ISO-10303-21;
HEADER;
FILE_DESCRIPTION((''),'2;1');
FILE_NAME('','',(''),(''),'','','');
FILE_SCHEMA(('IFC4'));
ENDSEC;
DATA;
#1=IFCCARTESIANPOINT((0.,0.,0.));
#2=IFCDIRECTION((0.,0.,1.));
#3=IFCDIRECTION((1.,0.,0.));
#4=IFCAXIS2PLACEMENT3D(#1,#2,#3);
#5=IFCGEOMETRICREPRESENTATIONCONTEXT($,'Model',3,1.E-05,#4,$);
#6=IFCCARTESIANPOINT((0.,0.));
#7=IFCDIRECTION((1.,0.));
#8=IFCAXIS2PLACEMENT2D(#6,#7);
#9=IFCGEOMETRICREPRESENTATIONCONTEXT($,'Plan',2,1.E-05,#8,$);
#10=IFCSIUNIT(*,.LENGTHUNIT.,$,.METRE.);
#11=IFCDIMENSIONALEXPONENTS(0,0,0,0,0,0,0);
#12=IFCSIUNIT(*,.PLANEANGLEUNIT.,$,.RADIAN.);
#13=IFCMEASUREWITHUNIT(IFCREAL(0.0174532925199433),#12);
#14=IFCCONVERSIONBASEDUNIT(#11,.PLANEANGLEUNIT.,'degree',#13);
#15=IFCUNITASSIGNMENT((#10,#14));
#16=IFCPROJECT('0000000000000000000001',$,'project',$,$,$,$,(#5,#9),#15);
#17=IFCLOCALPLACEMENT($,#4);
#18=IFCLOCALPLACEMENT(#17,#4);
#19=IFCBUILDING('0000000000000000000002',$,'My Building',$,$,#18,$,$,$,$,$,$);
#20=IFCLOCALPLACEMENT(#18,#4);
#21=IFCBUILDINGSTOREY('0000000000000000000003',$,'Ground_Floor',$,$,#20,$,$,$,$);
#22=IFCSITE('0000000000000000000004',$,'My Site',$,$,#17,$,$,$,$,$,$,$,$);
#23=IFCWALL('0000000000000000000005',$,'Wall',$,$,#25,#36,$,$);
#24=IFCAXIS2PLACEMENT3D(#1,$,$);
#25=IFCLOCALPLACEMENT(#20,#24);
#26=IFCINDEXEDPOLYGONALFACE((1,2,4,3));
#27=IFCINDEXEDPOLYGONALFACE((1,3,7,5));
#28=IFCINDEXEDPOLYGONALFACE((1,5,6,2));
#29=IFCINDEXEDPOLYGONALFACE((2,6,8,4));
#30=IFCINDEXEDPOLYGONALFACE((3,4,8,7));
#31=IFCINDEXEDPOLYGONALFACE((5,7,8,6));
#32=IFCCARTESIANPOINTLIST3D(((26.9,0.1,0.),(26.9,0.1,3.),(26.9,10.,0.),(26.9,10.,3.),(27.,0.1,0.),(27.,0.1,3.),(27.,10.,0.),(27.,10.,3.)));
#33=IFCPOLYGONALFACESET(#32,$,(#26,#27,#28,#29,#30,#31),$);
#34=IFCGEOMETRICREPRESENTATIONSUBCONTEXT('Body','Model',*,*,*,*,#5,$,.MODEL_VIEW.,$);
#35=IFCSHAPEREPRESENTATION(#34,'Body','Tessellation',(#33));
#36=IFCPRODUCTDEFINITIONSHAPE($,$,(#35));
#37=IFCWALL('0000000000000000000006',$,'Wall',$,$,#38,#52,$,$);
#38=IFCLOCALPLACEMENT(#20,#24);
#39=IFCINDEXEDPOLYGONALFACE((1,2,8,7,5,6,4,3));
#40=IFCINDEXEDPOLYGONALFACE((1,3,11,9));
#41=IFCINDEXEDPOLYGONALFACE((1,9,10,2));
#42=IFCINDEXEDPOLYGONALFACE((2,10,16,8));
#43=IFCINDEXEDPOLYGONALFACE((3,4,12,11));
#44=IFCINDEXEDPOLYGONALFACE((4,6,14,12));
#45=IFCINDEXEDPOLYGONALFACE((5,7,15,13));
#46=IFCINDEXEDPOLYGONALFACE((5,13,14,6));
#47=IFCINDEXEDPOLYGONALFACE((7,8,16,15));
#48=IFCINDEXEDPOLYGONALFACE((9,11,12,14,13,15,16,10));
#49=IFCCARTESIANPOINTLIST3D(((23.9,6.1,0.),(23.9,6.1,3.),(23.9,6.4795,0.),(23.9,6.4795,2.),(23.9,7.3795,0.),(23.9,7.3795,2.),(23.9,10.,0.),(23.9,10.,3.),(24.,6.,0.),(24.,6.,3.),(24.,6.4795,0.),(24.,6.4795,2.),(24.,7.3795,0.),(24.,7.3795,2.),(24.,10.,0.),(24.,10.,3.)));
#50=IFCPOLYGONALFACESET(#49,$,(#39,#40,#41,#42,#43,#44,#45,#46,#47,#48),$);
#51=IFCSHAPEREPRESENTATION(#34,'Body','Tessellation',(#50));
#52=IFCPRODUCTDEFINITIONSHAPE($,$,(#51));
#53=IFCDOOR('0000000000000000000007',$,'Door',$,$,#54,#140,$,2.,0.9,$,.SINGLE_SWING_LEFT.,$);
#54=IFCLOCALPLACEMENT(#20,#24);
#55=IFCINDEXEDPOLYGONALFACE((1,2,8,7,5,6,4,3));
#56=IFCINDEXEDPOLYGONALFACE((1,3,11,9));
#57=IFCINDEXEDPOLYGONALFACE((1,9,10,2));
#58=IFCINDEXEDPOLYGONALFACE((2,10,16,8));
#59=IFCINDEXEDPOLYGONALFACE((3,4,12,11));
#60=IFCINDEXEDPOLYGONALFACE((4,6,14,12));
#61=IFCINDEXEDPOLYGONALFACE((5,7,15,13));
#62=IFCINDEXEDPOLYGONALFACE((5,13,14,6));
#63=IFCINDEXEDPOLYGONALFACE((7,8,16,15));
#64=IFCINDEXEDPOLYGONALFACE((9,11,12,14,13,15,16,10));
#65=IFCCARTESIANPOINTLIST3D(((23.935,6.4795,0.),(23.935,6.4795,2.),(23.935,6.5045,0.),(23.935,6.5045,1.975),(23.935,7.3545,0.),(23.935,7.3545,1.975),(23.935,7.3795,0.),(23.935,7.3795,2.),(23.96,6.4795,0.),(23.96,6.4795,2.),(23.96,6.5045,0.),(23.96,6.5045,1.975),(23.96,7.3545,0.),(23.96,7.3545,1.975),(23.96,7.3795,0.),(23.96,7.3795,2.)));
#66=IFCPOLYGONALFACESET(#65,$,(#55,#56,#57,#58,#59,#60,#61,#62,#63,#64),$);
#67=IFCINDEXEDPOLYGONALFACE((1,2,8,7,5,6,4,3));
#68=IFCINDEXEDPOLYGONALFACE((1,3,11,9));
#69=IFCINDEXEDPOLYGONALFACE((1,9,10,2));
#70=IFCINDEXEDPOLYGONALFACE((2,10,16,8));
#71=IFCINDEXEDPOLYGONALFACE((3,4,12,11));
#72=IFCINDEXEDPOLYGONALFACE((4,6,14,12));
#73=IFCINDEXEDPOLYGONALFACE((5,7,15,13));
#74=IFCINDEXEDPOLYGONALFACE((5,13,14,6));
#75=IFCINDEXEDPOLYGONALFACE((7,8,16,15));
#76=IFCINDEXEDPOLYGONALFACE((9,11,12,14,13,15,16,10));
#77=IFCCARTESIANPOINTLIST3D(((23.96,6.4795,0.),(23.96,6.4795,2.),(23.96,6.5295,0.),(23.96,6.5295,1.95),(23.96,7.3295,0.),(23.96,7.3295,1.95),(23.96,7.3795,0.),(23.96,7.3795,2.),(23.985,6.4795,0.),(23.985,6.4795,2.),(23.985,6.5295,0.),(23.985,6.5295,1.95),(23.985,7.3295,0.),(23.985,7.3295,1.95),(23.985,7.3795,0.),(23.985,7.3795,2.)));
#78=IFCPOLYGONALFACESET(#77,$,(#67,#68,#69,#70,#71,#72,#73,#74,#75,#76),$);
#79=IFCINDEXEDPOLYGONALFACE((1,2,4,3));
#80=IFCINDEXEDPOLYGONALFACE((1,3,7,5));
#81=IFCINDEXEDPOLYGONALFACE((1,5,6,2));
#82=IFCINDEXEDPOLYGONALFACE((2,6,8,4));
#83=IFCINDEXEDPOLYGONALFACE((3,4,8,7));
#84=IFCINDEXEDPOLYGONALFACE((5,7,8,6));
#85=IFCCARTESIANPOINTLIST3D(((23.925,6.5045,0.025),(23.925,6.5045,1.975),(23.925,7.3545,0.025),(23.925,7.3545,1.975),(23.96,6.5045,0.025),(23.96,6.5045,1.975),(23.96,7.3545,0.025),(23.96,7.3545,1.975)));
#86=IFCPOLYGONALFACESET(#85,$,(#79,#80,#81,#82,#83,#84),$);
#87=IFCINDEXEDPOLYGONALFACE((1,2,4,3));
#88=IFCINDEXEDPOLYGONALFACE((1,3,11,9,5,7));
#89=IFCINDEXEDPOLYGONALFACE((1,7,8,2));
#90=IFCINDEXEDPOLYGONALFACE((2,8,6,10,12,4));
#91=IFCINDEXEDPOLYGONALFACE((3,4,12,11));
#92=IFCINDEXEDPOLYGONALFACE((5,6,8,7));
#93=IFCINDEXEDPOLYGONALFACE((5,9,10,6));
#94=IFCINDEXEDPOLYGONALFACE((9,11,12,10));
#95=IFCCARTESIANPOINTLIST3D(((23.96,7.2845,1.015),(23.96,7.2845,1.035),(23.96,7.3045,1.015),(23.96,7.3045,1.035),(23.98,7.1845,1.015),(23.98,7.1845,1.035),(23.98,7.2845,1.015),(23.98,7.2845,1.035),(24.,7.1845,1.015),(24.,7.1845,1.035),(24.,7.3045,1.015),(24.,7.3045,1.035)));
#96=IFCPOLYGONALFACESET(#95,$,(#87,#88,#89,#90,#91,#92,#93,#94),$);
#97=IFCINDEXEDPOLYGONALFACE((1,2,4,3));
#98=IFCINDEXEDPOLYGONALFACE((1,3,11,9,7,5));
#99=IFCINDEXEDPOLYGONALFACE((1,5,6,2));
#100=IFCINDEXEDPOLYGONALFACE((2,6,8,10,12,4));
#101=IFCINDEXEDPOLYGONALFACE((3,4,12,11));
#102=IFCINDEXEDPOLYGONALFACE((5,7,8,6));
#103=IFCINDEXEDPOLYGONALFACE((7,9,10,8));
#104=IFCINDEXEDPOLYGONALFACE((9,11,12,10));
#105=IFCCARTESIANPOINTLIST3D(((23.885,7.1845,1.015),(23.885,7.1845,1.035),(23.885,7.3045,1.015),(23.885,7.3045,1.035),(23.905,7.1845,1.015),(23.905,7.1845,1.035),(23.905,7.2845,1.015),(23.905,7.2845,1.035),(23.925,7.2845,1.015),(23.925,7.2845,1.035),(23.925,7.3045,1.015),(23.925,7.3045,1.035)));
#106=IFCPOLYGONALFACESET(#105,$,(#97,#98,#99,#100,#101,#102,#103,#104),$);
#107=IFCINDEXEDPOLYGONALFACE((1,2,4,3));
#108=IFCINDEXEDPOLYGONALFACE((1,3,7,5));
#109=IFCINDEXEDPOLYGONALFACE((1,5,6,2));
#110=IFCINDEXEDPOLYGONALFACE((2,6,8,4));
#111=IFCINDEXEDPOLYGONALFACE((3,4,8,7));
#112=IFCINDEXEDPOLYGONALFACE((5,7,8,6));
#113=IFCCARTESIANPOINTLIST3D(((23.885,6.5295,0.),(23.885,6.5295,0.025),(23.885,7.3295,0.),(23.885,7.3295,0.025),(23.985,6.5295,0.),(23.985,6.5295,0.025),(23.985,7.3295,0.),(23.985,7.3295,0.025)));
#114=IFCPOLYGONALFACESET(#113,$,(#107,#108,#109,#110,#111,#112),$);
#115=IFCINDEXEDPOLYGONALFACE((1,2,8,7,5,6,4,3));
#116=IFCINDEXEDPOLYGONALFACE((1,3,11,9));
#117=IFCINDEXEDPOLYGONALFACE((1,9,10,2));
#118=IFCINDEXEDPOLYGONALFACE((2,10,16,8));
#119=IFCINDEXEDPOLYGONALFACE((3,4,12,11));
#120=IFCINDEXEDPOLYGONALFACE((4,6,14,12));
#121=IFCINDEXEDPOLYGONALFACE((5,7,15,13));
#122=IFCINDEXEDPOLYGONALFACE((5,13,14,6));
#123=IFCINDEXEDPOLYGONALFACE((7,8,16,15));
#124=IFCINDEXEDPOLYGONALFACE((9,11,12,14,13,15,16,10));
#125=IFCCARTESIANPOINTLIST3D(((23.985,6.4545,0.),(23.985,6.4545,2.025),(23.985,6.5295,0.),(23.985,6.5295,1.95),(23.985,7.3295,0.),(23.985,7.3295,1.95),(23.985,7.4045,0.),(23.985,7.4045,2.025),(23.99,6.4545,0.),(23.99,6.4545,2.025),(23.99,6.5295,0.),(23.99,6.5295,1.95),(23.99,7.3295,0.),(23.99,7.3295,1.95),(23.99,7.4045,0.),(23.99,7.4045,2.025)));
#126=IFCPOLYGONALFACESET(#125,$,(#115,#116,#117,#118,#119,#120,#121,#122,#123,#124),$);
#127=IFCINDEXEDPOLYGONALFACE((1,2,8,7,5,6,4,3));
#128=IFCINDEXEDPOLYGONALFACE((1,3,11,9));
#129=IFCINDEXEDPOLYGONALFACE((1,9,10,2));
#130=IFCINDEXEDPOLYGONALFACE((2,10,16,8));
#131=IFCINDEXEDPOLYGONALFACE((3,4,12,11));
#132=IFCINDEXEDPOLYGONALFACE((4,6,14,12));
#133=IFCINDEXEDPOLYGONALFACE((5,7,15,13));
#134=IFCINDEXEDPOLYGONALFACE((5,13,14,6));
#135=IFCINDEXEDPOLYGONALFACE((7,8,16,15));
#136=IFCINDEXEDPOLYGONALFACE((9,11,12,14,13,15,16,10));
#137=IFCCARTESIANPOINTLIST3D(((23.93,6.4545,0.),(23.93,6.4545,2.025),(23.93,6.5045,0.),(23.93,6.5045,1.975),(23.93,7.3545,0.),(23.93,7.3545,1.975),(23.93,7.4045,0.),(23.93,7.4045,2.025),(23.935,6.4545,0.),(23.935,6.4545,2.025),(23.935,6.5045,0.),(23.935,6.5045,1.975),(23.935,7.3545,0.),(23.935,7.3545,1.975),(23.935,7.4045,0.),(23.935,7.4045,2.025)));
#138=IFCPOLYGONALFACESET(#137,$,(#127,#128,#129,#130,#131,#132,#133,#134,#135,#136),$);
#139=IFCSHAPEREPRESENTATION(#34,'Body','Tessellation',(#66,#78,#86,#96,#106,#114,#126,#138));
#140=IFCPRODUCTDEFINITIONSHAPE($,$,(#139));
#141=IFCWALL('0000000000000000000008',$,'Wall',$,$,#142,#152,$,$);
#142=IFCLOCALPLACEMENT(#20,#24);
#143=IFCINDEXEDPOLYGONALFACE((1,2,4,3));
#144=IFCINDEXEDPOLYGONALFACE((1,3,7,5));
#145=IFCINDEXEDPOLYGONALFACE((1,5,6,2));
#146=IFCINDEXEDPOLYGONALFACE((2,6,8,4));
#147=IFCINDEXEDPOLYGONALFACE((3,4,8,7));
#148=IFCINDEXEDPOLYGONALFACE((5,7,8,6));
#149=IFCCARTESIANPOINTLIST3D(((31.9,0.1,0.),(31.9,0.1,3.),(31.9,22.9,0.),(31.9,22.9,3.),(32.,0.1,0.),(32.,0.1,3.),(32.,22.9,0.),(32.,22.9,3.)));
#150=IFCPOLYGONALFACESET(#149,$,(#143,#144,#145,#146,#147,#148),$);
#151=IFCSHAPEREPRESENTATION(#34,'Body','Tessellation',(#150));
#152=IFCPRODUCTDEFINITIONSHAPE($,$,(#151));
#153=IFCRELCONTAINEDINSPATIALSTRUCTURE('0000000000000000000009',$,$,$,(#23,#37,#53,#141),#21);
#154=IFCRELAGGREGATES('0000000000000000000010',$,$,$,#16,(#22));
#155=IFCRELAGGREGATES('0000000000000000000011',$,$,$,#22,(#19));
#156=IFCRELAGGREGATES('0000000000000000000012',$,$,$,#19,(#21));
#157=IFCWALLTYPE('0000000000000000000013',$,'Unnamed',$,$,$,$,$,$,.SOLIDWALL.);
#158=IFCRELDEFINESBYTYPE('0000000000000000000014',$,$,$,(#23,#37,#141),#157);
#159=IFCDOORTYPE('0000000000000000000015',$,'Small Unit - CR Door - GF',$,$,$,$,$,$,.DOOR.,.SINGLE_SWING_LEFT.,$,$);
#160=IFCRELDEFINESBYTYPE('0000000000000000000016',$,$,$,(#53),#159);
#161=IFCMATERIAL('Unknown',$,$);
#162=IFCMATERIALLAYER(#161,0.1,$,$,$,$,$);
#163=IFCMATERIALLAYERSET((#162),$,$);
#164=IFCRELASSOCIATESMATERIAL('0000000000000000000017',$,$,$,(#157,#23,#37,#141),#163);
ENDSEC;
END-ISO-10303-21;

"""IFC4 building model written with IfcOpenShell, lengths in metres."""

from ifc_helpers import new_model, entity, si_unit, converted_unit, frame, origin_with_axes, origin_2d_with_axis, place, context, subcontext, project, spatial, line, indexed_curve, outline, extrude, shape, source, transform, mapped, material, layer, layer_set, layer_usage, type_object, type_shapes, element, fill, save


model = new_model("IFC4")

# Units and contexts
model_context = context("Model", 3, precision=1e-05, world=origin_with_axes())
plan_context = context("Plan", 2, precision=1e-05, world=origin_2d_with_axis())
body_context_1 = subcontext(model_context, "Body", "Model", "MODEL_VIEW")
body_context_2 = subcontext(plan_context, "Body", "Plan", "PLAN_VIEW")
ifc_project = project(units=[si_unit("LENGTHUNIT", "METRE"), converted_unit("PLANEANGLEUNIT", "degree", entity("IfcReal", 0.0174532925199433), si_unit("PLANEANGLEUNIT", "RADIAN"), dimensions=[0, 0, 0, 0, 0, 0, 0])], contexts=[model_context, plan_context])

# Site, building, storey
site_placement = place(None, origin_with_axes())
site = spatial("IfcSite", under=ifc_project, at=site_placement, Name="My Site")
building_placement = place(site_placement, origin_with_axes())
building = spatial("IfcBuilding", under=site, at=building_placement, Name="My Building")
storey_placement = place(building_placement, origin_with_axes())
storey = spatial("IfcBuildingStorey", under=building, at=storey_placement, Name="Ground_Floor")

# Wall
ifc_material = material(Name="Unknown")
ifc_layer = layer(ifc_material, 0.1)
ifc_layer_set = layer_set([ifc_layer])
ifc_layer_usage_1 = layer_usage(ifc_layer_set, "AXIS2", "POSITIVE", 0.0)
wall_type = type_object("IfcWallType", Name="Unnamed", PredefinedType="SOLIDWALL", material=ifc_layer_set)
wall_1_placement = place(storey_placement, frame((27.0, 0.0, 0.0), z_axis=(0.0, 0.0, 1.0), x_axis=(0.0, 1.0, 0.0)))
element("IfcWall", 1, at=wall_1_placement, inside=storey, type_object=wall_type, material=ifc_layer_usage_1, Name="Wall", context=body_context_1, shape_type="SweptSolid", body=[
    extrude(outline(indexed_curve([(0.1, 0.0), (0.1, 0.1), (10.0, 0.1), (10.0, 0.0)], segments=[line(1, 2, 3, 4, 1)])), origin_with_axes(), (0.0, 0.0, 1.0), 3.0),
])

# Wall, opening, door
ifc_layer_usage_2 = layer_usage(ifc_layer_set, "AXIS2", "POSITIVE", 0.0)
wall_2_placement = place(storey_placement, frame((24.0, 6.0, 0.0), z_axis=(0.0, 0.0, 1.0), x_axis=(0.0, 1.0, 0.0)))
wall_2 = element("IfcWall", 2, at=wall_2_placement, inside=storey, type_object=wall_type, material=ifc_layer_usage_2, Name="Wall", context=body_context_1, shape_type="SweptSolid", body=[
    extrude(outline(indexed_curve([(0.0, 0.0), (0.1, 0.1), (4.0, 0.1), (4.0, 0.0)], segments=[line(1, 2, 3, 4, 1)])), origin_with_axes(), (0.0, 0.0, 1.0), 3.0),
])
shared_shape_1 = source(origin_with_axes(), body_context_1, "Body", "SweptSolid", [
    extrude(outline(indexed_curve([(0.0, 0.0), (0.9, 0.0), (0.9, 2.0), (0.0, 2.0)], segments=[line(1, 2, 3, 4, 1)])), frame((0.0, -0.6, 0.0), z_axis=(0.0, -1.0, 0.0), x_axis=(1.0, 0.0, 0.0)), (0.0, 0.0, -1.0), 1.2),
])
opening_1_placement = place(wall_2_placement, frame((0.4795, 0.015, 0.0), z_axis=(0.0, 0.0, 1.0), x_axis=(1.0, 0.0, 0.0)))
opening_1 = element("IfcOpeningElement", 3, at=opening_1_placement, cuts=wall_2, PredefinedType="OPENING", context=body_context_1, shape_type="MappedRepresentation", body=[
    mapped(shared_shape_1, transform((0.0, 0.0, 0.0), x_axis=(1.0, 0.0, 0.0), y_axis=(0.0, 1.0, 0.0), z_axis=(0.0, 0.0, 1.0), scale=1.0)),
])
door_type_1 = type_object("IfcDoorType", Name="Small Unit - CR Door - GF", OperationType="SINGLE_SWING_LEFT", PredefinedType="DOOR")
shared_shape_2 = source(origin_with_axes(), body_context_1, "Body", "SweptSolid", [
    extrude(outline(indexed_curve([(0.0, 0.0), (0.0, 2.0), (0.9, 2.0), (0.9, 0.0), (0.875, 0.0), (0.875, 1.975), (0.025, 1.975), (0.025, 0.0)], segments=[line(1, 2, 3, 4, 5, 6, 7, 8, 1)])), frame((0.0, 0.025, 0.0), z_axis=(0.0, -1.0, 0.0), x_axis=(1.0, 0.0, 0.0)), (0.0, 0.0, -1.0), 0.025),
    extrude(outline(indexed_curve([(0.0, 0.0), (0.0, 2.0), (0.9, 2.0), (0.9, 0.0), (0.85, 0.0), (0.85, 1.95), (0.05, 1.95), (0.05, 0.0)], segments=[line(1, 2, 3, 4, 5, 6, 7, 8, 1)])), frame((0.0, 0.0, 0.0), z_axis=(0.0, -1.0, 0.0), x_axis=(1.0, 0.0, 0.0)), (0.0, 0.0, -1.0), 0.025),
    extrude(outline(indexed_curve([(0.0, 0.0), (0.85, 0.0), (0.85, 0.035), (0.0, 0.035)], segments=[line(1, 2, 3, 4, 1)])), frame((0.025, 0.025, 0.025), z_axis=(0.0, 0.0, 1.0), x_axis=(1.0, 0.0, 0.0)), (0.0, 0.0, 1.0), 1.95),
    extrude(outline(indexed_curve([(0.0, 0.0), (0.0, -0.04), (-0.12, -0.04), (-0.12, -0.02), (-0.02, -0.02), (-0.02, 0.0)], segments=[line(1, 2, 3, 4, 5, 6, 1)])), frame((0.825, 0.025, 1.015), z_axis=(0.0, 0.0, 1.0), x_axis=(1.0, 0.0, 0.0)), (0.0, 0.0, 1.0), 0.02),
    extrude(outline(indexed_curve([(0.0, 0.0), (0.0, 0.04), (-0.12, 0.04), (-0.12, 0.02), (-0.02, 0.02), (-0.02, 0.0)], segments=[line(1, 2, 3, 4, 5, 6, 1)])), frame((0.825, 0.06, 1.015), z_axis=(0.0, 0.0, 1.0), x_axis=(1.0, 0.0, 0.0)), (0.0, 0.0, 1.0), 0.02),
    extrude(outline(indexed_curve([(0.0, 0.0), (0.8, 0.0), (0.8, 0.1), (0.0, 0.1)], segments=[line(1, 2, 3, 4, 1)])), frame((0.05, 0.0, 0.0), z_axis=(0.0, 0.0, 1.0), x_axis=(1.0, 0.0, 0.0)), (0.0, 0.0, 1.0), 0.025),
    extrude(outline(indexed_curve([(0.0, 0.0), (0.0, 2.025), (0.95, 2.025), (0.95, 0.0), (0.875, 0.0), (0.875, 1.95), (0.075, 1.95), (0.075, 0.0)], segments=[line(1, 2, 3, 4, 5, 6, 7, 8, 1)])), frame((-0.025, -0.005, 0.0), z_axis=(0.0, -1.0, 0.0), x_axis=(1.0, 0.0, 0.0)), (0.0, 0.0, -1.0), 0.005),
    extrude(outline(indexed_curve([(0.0, 0.0), (0.0, 2.025), (0.95, 2.025), (0.95, 0.0), (0.9, 0.0), (0.9, 1.975), (0.05, 1.975), (0.05, 0.0)], segments=[line(1, 2, 3, 4, 5, 6, 7, 8, 1)])), frame((-0.025, 0.05, 0.0), z_axis=(0.0, -1.0, 0.0), x_axis=(1.0, 0.0, 0.0)), (0.0, 0.0, -1.0), 0.005),
])
shared_shape_3 = source(origin_with_axes(), body_context_2, "Body", "Curve2D", [
    entity("IfcIndexedPolyCurve", entity("IfcCartesianPointList2D", [[0.0, 0.0], [0.0, 0.05], [0.025, 0.05], [0.025, 0.025], [0.05, 0.025], [0.05, 0.0]]), [entity("IfcLineIndex", [1, 2, 3, 4, 5, 6, 1])]),
    entity("IfcIndexedPolyCurve", entity("IfcCartesianPointList2D", [[0.9, 0.0], [0.9, 0.05], [0.875, 0.05], [0.875, 0.025], [0.85, 0.025], [0.85, 0.0]]), [entity("IfcLineIndex", [1, 2, 3, 4, 5, 6, 1])]),
    entity("IfcTrimmedCurve", entity("IfcEllipse", entity("IfcAxis2Placement2D", entity("IfcCartesianPoint", [0.06, 0.05]), entity("IfcDirection", [1.0, 0.0])), 0.815, 0.85), [entity("IfcCartesianPoint", [0.875, 0.05])], [entity("IfcCartesianPoint", [0.06, 0.9])], True, "CARTESIAN"),
    entity("IfcIndexedPolyCurve", entity("IfcCartesianPointList2D", [[0.025, 0.05], [0.06, 0.05], [0.06, 0.9], [0.025, 0.9]]), [entity("IfcLineIndex", [1, 2, 3, 4, 1])]),
])
type_shapes(door_type_1, [shared_shape_2, shared_shape_3])
door_1_placement = place(opening_1_placement, origin_with_axes())
door_1 = element("IfcDoor", 4, at=door_1_placement, inside=storey, type_object=door_type_1, Name="Door", OperationType="SINGLE_SWING_LEFT", OverallHeight=2.0, OverallWidth=0.9, shapes=[
    shape(body_context_1, "Body", "MappedRepresentation", [mapped(shared_shape_2, transform((0.0, 0.0, 0.0), x_axis=(1.0, 0.0, 0.0), y_axis=(0.0, 1.0, 0.0), z_axis=(0.0, 0.0, 1.0), scale=1.0))]),
    shape(body_context_2, "Body", "MappedRepresentation", [mapped(shared_shape_3, transform((0.0, 0.0, 0.0), x_axis=(1.0, 0.0, 0.0), y_axis=(0.0, 1.0, 0.0), z_axis=(0.0, 0.0, 1.0), scale=1.0))]),
])
fill(opening_1, door_1)

# Wall
ifc_layer_usage_3 = layer_usage(ifc_layer_set, "AXIS2", "POSITIVE", 0.0)
wall_3_placement = place(storey_placement, frame((32.0, 0.0, 0.0), z_axis=(0.0, 0.0, 1.0), x_axis=(0.0, 1.0, 0.0)))
element("IfcWall", 5, at=wall_3_placement, inside=storey, type_object=wall_type, material=ifc_layer_usage_3, Name="Wall", context=body_context_1, shape_type="SweptSolid", body=[
    extrude(outline(indexed_curve([(0.1, 0.0), (0.1, 0.1), (22.9, 0.1), (22.9, 0.0)], segments=[line(1, 2, 3, 4, 1)])), origin_with_axes(), (0.0, 0.0, 1.0), 3.0),
])

save(model, "model.ifc")
